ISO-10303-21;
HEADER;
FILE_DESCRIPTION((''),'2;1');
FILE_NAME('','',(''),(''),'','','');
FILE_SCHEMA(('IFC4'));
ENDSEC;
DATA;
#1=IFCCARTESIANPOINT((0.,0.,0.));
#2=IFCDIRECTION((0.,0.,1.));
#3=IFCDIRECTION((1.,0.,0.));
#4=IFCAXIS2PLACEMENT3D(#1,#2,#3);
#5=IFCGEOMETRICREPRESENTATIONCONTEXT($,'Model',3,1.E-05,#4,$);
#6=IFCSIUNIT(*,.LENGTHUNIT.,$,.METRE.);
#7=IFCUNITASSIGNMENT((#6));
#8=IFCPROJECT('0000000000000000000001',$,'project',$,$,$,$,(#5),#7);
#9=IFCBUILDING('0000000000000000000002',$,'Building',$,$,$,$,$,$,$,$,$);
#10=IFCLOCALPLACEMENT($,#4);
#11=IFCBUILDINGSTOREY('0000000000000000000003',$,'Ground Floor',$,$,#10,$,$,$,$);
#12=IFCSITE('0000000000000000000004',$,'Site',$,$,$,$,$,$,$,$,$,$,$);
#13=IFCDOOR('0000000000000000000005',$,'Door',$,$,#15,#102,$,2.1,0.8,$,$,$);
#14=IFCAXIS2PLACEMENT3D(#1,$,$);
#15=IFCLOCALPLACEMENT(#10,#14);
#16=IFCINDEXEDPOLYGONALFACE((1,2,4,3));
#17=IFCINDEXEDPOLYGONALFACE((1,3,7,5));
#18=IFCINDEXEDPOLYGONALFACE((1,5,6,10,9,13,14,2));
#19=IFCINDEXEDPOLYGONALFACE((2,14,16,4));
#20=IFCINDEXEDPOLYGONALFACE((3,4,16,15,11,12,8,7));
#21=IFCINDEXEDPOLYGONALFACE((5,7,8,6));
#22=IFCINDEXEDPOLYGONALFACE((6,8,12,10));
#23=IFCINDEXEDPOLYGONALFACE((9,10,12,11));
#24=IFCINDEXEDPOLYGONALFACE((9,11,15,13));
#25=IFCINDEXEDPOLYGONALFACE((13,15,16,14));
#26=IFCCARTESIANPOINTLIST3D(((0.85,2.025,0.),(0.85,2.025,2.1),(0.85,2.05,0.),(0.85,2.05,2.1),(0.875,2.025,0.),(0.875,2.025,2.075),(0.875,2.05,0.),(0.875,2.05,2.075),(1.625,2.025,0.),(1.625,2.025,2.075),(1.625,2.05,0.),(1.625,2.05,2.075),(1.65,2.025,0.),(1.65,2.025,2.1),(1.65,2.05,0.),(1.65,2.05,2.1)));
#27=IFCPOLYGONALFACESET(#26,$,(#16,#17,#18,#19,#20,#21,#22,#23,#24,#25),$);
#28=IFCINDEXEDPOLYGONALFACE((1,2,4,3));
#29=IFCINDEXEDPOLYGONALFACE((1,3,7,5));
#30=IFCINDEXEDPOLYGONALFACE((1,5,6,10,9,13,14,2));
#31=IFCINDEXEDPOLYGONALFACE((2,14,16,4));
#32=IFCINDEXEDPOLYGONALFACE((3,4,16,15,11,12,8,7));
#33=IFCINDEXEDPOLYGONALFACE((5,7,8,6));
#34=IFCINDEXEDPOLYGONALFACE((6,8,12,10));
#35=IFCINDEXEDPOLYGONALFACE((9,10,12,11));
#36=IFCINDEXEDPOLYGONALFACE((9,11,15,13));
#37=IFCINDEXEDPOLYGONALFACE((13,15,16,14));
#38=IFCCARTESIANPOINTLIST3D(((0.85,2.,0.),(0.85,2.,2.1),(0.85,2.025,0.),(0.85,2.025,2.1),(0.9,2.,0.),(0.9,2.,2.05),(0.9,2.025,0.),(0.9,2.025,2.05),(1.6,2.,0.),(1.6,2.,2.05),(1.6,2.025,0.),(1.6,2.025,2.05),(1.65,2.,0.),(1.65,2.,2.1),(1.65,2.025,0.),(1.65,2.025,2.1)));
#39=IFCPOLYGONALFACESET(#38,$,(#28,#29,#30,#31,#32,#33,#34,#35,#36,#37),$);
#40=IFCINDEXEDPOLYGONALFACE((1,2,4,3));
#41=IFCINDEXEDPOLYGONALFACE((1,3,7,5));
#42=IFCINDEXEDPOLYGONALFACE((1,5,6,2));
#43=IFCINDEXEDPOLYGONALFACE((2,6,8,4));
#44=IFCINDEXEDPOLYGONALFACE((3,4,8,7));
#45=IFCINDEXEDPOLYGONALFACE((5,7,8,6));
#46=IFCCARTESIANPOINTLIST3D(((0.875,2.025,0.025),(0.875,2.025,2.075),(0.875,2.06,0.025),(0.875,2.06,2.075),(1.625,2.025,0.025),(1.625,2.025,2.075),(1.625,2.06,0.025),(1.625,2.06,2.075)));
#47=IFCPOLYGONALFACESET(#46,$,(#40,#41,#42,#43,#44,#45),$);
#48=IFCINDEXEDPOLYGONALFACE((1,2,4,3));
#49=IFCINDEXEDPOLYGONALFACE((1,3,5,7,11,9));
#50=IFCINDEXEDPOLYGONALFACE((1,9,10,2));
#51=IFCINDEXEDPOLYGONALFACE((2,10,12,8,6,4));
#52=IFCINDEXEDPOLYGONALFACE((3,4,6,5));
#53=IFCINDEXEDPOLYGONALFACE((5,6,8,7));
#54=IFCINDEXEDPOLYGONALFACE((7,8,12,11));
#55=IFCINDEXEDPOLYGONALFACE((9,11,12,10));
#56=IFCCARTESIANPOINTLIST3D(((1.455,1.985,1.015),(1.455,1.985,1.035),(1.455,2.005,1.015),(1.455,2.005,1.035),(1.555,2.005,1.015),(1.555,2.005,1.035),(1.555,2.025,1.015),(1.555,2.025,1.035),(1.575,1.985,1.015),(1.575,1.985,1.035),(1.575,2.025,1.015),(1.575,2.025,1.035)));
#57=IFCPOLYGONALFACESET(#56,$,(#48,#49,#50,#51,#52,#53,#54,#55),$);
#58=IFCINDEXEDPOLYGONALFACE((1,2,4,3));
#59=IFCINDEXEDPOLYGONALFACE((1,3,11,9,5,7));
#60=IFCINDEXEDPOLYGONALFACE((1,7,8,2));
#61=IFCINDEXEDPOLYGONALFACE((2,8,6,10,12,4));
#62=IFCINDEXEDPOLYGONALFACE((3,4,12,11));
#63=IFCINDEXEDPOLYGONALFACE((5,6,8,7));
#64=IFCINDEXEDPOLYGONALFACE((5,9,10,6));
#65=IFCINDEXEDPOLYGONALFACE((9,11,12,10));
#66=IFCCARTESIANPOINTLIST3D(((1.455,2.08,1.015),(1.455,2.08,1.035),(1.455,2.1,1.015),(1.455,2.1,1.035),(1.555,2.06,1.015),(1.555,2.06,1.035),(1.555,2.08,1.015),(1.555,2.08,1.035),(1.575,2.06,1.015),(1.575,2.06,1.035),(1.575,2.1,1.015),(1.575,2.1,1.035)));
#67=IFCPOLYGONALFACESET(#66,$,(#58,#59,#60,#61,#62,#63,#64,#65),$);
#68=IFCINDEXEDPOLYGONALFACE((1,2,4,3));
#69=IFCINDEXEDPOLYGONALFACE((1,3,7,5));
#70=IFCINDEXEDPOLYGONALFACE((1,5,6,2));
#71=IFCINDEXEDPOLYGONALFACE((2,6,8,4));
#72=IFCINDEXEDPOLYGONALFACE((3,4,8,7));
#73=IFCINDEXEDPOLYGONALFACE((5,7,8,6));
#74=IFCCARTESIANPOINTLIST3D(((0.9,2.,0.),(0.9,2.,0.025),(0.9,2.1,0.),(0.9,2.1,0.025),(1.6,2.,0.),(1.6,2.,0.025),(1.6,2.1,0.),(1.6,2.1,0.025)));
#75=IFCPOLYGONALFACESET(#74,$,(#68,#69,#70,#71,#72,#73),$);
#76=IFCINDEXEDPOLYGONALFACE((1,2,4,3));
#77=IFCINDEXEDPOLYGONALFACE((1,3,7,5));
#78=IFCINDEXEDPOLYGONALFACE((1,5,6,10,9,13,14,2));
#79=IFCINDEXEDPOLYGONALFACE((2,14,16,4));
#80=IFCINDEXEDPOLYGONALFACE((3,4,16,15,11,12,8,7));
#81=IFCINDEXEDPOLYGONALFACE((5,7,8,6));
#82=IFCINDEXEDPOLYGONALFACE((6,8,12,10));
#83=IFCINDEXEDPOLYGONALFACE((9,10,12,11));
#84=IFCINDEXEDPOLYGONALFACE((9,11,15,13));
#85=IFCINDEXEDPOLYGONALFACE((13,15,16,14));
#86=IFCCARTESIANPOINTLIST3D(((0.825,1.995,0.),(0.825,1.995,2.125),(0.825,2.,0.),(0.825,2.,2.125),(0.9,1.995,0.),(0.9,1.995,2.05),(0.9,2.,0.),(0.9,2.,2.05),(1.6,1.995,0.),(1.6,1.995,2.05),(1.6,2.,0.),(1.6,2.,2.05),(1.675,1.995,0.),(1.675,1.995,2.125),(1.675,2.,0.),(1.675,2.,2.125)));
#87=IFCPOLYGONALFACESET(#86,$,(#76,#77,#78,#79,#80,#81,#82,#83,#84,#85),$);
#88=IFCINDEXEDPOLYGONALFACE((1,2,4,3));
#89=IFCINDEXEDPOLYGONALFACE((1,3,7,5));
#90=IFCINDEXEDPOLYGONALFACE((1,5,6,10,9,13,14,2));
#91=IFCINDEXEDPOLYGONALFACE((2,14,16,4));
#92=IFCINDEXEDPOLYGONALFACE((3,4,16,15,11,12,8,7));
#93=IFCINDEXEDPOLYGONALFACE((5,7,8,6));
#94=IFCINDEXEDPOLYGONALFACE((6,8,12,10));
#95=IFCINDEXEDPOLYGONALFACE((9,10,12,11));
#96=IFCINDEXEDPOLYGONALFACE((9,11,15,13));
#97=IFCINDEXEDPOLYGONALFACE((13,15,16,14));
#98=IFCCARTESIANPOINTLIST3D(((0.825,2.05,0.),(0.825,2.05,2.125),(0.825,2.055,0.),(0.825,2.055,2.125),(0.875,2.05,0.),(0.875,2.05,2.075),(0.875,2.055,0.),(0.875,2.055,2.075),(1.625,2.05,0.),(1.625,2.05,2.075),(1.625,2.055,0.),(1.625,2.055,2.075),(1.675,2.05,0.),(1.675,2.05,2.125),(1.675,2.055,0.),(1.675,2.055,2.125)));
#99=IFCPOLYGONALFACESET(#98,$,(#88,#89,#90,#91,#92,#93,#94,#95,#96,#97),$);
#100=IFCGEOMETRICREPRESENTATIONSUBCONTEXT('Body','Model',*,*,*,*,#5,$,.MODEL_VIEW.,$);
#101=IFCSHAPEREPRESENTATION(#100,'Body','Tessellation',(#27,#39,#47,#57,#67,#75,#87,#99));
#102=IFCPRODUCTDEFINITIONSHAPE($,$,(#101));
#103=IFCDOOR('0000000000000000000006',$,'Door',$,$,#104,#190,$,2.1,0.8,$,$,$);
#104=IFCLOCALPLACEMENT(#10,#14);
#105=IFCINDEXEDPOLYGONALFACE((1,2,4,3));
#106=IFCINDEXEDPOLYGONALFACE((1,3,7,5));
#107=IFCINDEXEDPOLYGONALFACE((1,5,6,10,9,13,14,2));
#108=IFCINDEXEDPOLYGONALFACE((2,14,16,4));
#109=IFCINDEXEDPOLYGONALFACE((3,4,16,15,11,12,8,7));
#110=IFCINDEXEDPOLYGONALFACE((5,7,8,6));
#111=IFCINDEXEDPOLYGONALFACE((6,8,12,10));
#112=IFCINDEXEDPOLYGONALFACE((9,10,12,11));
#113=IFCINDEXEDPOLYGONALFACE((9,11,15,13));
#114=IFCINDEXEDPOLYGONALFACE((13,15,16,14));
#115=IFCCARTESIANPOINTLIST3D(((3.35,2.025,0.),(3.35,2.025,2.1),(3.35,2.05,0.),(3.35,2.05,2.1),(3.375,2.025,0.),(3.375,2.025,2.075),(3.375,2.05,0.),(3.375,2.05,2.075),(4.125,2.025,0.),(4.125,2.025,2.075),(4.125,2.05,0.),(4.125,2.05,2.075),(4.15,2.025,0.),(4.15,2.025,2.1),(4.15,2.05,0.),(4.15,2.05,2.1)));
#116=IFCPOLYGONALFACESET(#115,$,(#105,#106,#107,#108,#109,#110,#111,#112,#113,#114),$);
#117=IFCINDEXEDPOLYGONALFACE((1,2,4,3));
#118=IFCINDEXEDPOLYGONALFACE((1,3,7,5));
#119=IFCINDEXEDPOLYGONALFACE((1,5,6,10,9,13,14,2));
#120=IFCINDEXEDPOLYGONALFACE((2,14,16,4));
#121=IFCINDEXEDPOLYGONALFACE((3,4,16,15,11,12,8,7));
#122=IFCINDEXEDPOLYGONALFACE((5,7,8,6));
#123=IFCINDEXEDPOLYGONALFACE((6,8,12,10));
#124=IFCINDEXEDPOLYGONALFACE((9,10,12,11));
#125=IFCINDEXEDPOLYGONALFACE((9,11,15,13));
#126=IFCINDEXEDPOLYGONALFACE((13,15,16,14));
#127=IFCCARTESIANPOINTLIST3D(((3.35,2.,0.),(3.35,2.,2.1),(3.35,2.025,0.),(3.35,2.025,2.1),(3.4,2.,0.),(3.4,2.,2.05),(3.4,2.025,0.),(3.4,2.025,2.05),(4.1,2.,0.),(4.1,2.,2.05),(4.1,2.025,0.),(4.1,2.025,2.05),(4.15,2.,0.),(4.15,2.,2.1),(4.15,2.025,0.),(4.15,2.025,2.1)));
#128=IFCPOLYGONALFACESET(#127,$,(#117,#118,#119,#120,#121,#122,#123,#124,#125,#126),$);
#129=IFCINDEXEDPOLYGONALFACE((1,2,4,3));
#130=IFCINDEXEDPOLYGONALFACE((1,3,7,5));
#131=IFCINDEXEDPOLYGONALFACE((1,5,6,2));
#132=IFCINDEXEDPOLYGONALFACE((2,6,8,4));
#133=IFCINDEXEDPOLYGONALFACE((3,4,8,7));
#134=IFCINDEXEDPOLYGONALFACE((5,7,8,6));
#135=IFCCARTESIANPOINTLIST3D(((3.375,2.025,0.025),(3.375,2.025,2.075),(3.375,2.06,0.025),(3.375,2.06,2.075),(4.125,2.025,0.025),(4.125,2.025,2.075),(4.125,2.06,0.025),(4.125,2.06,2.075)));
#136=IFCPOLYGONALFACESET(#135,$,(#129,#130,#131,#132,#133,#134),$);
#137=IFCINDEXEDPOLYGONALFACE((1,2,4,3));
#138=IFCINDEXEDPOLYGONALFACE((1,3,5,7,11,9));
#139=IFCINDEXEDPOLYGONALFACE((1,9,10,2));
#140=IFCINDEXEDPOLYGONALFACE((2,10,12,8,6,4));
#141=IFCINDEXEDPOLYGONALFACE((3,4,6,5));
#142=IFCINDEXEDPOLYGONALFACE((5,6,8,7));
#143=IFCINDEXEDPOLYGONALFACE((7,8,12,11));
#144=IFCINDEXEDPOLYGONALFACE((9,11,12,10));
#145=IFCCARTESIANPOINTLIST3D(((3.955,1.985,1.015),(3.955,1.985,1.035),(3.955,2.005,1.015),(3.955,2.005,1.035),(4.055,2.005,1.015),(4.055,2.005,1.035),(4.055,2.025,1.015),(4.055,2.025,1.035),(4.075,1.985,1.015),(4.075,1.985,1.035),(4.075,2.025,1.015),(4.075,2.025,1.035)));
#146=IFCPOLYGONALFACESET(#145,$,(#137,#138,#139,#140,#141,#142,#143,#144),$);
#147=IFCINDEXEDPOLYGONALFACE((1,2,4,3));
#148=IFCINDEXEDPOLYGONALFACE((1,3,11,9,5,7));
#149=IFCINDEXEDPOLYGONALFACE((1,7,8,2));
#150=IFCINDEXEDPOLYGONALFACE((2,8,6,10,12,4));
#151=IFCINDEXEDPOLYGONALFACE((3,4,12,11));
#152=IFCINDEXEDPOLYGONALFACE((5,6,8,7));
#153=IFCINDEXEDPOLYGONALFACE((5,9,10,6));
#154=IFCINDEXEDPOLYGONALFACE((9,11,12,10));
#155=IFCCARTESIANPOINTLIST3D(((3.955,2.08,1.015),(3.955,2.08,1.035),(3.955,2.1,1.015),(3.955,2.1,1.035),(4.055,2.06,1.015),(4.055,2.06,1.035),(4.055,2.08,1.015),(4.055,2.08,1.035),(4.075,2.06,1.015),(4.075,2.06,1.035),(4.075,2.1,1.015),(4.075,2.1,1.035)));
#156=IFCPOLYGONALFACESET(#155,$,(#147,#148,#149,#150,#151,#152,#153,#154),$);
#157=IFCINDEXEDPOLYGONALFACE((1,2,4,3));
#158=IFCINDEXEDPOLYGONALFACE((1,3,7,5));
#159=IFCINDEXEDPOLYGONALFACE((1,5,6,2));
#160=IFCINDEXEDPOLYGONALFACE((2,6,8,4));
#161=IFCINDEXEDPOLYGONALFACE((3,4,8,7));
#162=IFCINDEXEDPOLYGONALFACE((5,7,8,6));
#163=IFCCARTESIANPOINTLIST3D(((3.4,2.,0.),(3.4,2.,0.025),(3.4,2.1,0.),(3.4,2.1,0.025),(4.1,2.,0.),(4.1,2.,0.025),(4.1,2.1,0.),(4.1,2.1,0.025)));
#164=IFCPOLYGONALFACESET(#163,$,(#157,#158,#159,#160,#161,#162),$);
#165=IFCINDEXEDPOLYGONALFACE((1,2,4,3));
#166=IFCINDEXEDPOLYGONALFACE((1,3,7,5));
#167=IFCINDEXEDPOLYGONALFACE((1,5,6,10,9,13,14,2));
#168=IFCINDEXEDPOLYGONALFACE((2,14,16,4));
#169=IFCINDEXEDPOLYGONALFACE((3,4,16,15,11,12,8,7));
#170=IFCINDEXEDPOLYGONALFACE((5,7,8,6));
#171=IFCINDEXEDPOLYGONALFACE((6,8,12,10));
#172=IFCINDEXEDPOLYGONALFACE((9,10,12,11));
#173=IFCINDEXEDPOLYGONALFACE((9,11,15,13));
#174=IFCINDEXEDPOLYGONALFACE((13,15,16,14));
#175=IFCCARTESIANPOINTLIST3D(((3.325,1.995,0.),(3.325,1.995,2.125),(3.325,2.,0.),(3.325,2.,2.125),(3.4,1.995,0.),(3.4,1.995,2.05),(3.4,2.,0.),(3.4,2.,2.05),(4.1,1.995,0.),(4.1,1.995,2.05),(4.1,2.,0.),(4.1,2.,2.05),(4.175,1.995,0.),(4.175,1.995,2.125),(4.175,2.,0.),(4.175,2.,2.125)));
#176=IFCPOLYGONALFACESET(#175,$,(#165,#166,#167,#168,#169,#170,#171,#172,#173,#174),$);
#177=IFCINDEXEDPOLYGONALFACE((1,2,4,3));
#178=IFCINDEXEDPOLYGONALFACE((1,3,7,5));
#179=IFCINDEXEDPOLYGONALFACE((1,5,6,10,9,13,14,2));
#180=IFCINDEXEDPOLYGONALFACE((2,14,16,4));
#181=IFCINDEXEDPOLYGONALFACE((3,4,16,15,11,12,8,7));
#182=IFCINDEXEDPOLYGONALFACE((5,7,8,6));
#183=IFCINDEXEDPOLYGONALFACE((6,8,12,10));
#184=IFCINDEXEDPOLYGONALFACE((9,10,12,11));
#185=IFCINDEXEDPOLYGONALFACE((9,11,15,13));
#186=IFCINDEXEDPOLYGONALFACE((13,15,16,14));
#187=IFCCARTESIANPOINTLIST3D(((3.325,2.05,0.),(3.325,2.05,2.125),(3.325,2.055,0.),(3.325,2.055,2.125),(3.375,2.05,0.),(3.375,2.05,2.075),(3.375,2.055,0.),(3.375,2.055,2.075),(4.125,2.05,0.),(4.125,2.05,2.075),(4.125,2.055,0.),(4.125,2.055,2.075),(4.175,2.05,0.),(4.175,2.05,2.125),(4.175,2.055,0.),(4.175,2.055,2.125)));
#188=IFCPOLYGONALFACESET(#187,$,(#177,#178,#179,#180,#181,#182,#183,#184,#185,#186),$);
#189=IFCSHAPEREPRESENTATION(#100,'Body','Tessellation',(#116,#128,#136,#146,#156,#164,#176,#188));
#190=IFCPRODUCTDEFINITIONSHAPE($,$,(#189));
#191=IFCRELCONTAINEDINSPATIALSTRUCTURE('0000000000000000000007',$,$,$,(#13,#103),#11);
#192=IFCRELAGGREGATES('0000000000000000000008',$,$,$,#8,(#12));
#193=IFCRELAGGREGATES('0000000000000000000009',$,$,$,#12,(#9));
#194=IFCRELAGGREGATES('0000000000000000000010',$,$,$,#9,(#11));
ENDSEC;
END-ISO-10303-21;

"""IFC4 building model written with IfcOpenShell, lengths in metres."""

from ifc_helpers import new_model, si_unit, frame, origin_with_axes, place, context, subcontext, project, spatial, line, indexed_curve, outline, extrude, element, save


model = new_model("IFC4")

# Units and contexts
model_context = context("Model", 3, precision=1e-05, world=origin_with_axes())
body_context = subcontext(model_context, "Body", "Model", "MODEL_VIEW")
ifc_project = project(units=[si_unit("LENGTHUNIT", "METRE")], contexts=[model_context])

# Site, building, storey
site = spatial("IfcSite", under=ifc_project, Name="Site")
building = spatial("IfcBuilding", under=site, Name="Building")
storey_placement = place(None, origin_with_axes())
storey = spatial("IfcBuildingStorey", under=building, at=storey_placement, Name="Ground Floor")

# Doors
door_1_placement = place(storey_placement, frame((0.85, 2.0, 0.0), z_axis=(0.0, 0.0, 1.0), x_axis=(1.0, 0.0, 0.0)))
element("IfcDoor", 1, at=door_1_placement, inside=storey, Name="Door", OverallHeight=2.1, OverallWidth=0.8, context=body_context, shape_type="SweptSolid", body=[
    extrude(outline(indexed_curve([(0.0, 0.0), (0.0, 2.1), (0.8, 2.1), (0.8, 0.0), (0.775, 0.0), (0.775, 2.075), (0.025, 2.075), (0.025, 0.0)], segments=[line(1, 2, 3, 4, 5, 6, 7, 8, 1)])), frame((0.0, 0.025, 0.0), z_axis=(0.0, -1.0, 0.0), x_axis=(1.0, 0.0, 0.0)), (0.0, 0.0, -1.0), 0.025),
    extrude(outline(indexed_curve([(0.0, 0.0), (0.0, 2.1), (0.8, 2.1), (0.8, 0.0), (0.75, 0.0), (0.75, 2.05), (0.05, 2.05), (0.05, 0.0)], segments=[line(1, 2, 3, 4, 5, 6, 7, 8, 1)])), frame((0.0, 0.0, 0.0), z_axis=(0.0, -1.0, 0.0), x_axis=(1.0, 0.0, 0.0)), (0.0, 0.0, -1.0), 0.025),
    extrude(outline(indexed_curve([(0.0, 0.0), (0.75, 0.0), (0.75, 0.035), (0.0, 0.035)], segments=[line(1, 2, 3, 4, 1)])), frame((0.025, 0.025, 0.025), z_axis=(0.0, 0.0, 1.0), x_axis=(1.0, 0.0, 0.0)), (0.0, 0.0, 1.0), 2.05),
    extrude(outline(indexed_curve([(0.0, 0.0), (0.0, -0.04), (-0.12, -0.04), (-0.12, -0.02), (-0.02, -0.02), (-0.02, 0.0)], segments=[line(1, 2, 3, 4, 5, 6, 1)])), frame((0.725, 0.025, 1.015), z_axis=(0.0, 0.0, 1.0), x_axis=(1.0, 0.0, 0.0)), (0.0, 0.0, 1.0), 0.02),
    extrude(outline(indexed_curve([(0.0, 0.0), (0.0, 0.04), (-0.12, 0.04), (-0.12, 0.02), (-0.02, 0.02), (-0.02, 0.0)], segments=[line(1, 2, 3, 4, 5, 6, 1)])), frame((0.725, 0.06, 1.015), z_axis=(0.0, 0.0, 1.0), x_axis=(1.0, 0.0, 0.0)), (0.0, 0.0, 1.0), 0.02),
    extrude(outline(indexed_curve([(0.0, 0.0), (0.7, 0.0), (0.7, 0.1), (0.0, 0.1)], segments=[line(1, 2, 3, 4, 1)])), frame((0.05, 0.0, 0.0), z_axis=(0.0, 0.0, 1.0), x_axis=(1.0, 0.0, 0.0)), (0.0, 0.0, 1.0), 0.025),
    extrude(outline(indexed_curve([(0.0, 0.0), (0.0, 2.125), (0.85, 2.125), (0.85, 0.0), (0.775, 0.0), (0.775, 2.05), (0.075, 2.05), (0.075, 0.0)], segments=[line(1, 2, 3, 4, 5, 6, 7, 8, 1)])), frame((-0.025, -0.005, 0.0), z_axis=(0.0, -1.0, 0.0), x_axis=(1.0, 0.0, 0.0)), (0.0, 0.0, -1.0), 0.005),
    extrude(outline(indexed_curve([(0.0, 0.0), (0.0, 2.125), (0.85, 2.125), (0.85, 0.0), (0.8, 0.0), (0.8, 2.075), (0.05, 2.075), (0.05, 0.0)], segments=[line(1, 2, 3, 4, 5, 6, 7, 8, 1)])), frame((-0.025, 0.05, 0.0), z_axis=(0.0, -1.0, 0.0), x_axis=(1.0, 0.0, 0.0)), (0.0, 0.0, -1.0), 0.005),
])
door_2_placement = place(storey_placement, frame((3.35, 2.0, 0.0), z_axis=(0.0, 0.0, 1.0), x_axis=(1.0, 0.0, 0.0)))
element("IfcDoor", 2, at=door_2_placement, inside=storey, Name="Door", OverallHeight=2.1, OverallWidth=0.8, context=body_context, shape_type="SweptSolid", body=[
    extrude(outline(indexed_curve([(0.0, 0.0), (0.0, 2.1), (0.8, 2.1), (0.8, 0.0), (0.775, 0.0), (0.775, 2.075), (0.025, 2.075), (0.025, 0.0)], segments=[line(1, 2, 3, 4, 5, 6, 7, 8, 1)])), frame((0.0, 0.025, 0.0), z_axis=(0.0, -1.0, 0.0), x_axis=(1.0, 0.0, 0.0)), (0.0, 0.0, -1.0), 0.025),
    extrude(outline(indexed_curve([(0.0, 0.0), (0.0, 2.1), (0.8, 2.1), (0.8, 0.0), (0.75, 0.0), (0.75, 2.05), (0.05, 2.05), (0.05, 0.0)], segments=[line(1, 2, 3, 4, 5, 6, 7, 8, 1)])), frame((0.0, 0.0, 0.0), z_axis=(0.0, -1.0, 0.0), x_axis=(1.0, 0.0, 0.0)), (0.0, 0.0, -1.0), 0.025),
    extrude(outline(indexed_curve([(0.0, 0.0), (0.75, 0.0), (0.75, 0.035), (0.0, 0.035)], segments=[line(1, 2, 3, 4, 1)])), frame((0.025, 0.025, 0.025), z_axis=(0.0, 0.0, 1.0), x_axis=(1.0, 0.0, 0.0)), (0.0, 0.0, 1.0), 2.05),
    extrude(outline(indexed_curve([(0.0, 0.0), (0.0, -0.04), (-0.12, -0.04), (-0.12, -0.02), (-0.02, -0.02), (-0.02, 0.0)], segments=[line(1, 2, 3, 4, 5, 6, 1)])), frame((0.725, 0.025, 1.015), z_axis=(0.0, 0.0, 1.0), x_axis=(1.0, 0.0, 0.0)), (0.0, 0.0, 1.0), 0.02),
    extrude(outline(indexed_curve([(0.0, 0.0), (0.0, 0.04), (-0.12, 0.04), (-0.12, 0.02), (-0.02, 0.02), (-0.02, 0.0)], segments=[line(1, 2, 3, 4, 5, 6, 1)])), frame((0.725, 0.06, 1.015), z_axis=(0.0, 0.0, 1.0), x_axis=(1.0, 0.0, 0.0)), (0.0, 0.0, 1.0), 0.02),
    extrude(outline(indexed_curve([(0.0, 0.0), (0.7, 0.0), (0.7, 0.1), (0.0, 0.1)], segments=[line(1, 2, 3, 4, 1)])), frame((0.05, 0.0, 0.0), z_axis=(0.0, 0.0, 1.0), x_axis=(1.0, 0.0, 0.0)), (0.0, 0.0, 1.0), 0.025),
    extrude(outline(indexed_curve([(0.0, 0.0), (0.0, 2.125), (0.85, 2.125), (0.85, 0.0), (0.775, 0.0), (0.775, 2.05), (0.075, 2.05), (0.075, 0.0)], segments=[line(1, 2, 3, 4, 5, 6, 7, 8, 1)])), frame((-0.025, -0.005, 0.0), z_axis=(0.0, -1.0, 0.0), x_axis=(1.0, 0.0, 0.0)), (0.0, 0.0, -1.0), 0.005),
    extrude(outline(indexed_curve([(0.0, 0.0), (0.0, 2.125), (0.85, 2.125), (0.85, 0.0), (0.8, 0.0), (0.8, 2.075), (0.05, 2.075), (0.05, 0.0)], segments=[line(1, 2, 3, 4, 5, 6, 7, 8, 1)])), frame((-0.025, 0.05, 0.0), z_axis=(0.0, -1.0, 0.0), x_axis=(1.0, 0.0, 0.0)), (0.0, 0.0, -1.0), 0.005),
])

save(model, "model.ifc")
